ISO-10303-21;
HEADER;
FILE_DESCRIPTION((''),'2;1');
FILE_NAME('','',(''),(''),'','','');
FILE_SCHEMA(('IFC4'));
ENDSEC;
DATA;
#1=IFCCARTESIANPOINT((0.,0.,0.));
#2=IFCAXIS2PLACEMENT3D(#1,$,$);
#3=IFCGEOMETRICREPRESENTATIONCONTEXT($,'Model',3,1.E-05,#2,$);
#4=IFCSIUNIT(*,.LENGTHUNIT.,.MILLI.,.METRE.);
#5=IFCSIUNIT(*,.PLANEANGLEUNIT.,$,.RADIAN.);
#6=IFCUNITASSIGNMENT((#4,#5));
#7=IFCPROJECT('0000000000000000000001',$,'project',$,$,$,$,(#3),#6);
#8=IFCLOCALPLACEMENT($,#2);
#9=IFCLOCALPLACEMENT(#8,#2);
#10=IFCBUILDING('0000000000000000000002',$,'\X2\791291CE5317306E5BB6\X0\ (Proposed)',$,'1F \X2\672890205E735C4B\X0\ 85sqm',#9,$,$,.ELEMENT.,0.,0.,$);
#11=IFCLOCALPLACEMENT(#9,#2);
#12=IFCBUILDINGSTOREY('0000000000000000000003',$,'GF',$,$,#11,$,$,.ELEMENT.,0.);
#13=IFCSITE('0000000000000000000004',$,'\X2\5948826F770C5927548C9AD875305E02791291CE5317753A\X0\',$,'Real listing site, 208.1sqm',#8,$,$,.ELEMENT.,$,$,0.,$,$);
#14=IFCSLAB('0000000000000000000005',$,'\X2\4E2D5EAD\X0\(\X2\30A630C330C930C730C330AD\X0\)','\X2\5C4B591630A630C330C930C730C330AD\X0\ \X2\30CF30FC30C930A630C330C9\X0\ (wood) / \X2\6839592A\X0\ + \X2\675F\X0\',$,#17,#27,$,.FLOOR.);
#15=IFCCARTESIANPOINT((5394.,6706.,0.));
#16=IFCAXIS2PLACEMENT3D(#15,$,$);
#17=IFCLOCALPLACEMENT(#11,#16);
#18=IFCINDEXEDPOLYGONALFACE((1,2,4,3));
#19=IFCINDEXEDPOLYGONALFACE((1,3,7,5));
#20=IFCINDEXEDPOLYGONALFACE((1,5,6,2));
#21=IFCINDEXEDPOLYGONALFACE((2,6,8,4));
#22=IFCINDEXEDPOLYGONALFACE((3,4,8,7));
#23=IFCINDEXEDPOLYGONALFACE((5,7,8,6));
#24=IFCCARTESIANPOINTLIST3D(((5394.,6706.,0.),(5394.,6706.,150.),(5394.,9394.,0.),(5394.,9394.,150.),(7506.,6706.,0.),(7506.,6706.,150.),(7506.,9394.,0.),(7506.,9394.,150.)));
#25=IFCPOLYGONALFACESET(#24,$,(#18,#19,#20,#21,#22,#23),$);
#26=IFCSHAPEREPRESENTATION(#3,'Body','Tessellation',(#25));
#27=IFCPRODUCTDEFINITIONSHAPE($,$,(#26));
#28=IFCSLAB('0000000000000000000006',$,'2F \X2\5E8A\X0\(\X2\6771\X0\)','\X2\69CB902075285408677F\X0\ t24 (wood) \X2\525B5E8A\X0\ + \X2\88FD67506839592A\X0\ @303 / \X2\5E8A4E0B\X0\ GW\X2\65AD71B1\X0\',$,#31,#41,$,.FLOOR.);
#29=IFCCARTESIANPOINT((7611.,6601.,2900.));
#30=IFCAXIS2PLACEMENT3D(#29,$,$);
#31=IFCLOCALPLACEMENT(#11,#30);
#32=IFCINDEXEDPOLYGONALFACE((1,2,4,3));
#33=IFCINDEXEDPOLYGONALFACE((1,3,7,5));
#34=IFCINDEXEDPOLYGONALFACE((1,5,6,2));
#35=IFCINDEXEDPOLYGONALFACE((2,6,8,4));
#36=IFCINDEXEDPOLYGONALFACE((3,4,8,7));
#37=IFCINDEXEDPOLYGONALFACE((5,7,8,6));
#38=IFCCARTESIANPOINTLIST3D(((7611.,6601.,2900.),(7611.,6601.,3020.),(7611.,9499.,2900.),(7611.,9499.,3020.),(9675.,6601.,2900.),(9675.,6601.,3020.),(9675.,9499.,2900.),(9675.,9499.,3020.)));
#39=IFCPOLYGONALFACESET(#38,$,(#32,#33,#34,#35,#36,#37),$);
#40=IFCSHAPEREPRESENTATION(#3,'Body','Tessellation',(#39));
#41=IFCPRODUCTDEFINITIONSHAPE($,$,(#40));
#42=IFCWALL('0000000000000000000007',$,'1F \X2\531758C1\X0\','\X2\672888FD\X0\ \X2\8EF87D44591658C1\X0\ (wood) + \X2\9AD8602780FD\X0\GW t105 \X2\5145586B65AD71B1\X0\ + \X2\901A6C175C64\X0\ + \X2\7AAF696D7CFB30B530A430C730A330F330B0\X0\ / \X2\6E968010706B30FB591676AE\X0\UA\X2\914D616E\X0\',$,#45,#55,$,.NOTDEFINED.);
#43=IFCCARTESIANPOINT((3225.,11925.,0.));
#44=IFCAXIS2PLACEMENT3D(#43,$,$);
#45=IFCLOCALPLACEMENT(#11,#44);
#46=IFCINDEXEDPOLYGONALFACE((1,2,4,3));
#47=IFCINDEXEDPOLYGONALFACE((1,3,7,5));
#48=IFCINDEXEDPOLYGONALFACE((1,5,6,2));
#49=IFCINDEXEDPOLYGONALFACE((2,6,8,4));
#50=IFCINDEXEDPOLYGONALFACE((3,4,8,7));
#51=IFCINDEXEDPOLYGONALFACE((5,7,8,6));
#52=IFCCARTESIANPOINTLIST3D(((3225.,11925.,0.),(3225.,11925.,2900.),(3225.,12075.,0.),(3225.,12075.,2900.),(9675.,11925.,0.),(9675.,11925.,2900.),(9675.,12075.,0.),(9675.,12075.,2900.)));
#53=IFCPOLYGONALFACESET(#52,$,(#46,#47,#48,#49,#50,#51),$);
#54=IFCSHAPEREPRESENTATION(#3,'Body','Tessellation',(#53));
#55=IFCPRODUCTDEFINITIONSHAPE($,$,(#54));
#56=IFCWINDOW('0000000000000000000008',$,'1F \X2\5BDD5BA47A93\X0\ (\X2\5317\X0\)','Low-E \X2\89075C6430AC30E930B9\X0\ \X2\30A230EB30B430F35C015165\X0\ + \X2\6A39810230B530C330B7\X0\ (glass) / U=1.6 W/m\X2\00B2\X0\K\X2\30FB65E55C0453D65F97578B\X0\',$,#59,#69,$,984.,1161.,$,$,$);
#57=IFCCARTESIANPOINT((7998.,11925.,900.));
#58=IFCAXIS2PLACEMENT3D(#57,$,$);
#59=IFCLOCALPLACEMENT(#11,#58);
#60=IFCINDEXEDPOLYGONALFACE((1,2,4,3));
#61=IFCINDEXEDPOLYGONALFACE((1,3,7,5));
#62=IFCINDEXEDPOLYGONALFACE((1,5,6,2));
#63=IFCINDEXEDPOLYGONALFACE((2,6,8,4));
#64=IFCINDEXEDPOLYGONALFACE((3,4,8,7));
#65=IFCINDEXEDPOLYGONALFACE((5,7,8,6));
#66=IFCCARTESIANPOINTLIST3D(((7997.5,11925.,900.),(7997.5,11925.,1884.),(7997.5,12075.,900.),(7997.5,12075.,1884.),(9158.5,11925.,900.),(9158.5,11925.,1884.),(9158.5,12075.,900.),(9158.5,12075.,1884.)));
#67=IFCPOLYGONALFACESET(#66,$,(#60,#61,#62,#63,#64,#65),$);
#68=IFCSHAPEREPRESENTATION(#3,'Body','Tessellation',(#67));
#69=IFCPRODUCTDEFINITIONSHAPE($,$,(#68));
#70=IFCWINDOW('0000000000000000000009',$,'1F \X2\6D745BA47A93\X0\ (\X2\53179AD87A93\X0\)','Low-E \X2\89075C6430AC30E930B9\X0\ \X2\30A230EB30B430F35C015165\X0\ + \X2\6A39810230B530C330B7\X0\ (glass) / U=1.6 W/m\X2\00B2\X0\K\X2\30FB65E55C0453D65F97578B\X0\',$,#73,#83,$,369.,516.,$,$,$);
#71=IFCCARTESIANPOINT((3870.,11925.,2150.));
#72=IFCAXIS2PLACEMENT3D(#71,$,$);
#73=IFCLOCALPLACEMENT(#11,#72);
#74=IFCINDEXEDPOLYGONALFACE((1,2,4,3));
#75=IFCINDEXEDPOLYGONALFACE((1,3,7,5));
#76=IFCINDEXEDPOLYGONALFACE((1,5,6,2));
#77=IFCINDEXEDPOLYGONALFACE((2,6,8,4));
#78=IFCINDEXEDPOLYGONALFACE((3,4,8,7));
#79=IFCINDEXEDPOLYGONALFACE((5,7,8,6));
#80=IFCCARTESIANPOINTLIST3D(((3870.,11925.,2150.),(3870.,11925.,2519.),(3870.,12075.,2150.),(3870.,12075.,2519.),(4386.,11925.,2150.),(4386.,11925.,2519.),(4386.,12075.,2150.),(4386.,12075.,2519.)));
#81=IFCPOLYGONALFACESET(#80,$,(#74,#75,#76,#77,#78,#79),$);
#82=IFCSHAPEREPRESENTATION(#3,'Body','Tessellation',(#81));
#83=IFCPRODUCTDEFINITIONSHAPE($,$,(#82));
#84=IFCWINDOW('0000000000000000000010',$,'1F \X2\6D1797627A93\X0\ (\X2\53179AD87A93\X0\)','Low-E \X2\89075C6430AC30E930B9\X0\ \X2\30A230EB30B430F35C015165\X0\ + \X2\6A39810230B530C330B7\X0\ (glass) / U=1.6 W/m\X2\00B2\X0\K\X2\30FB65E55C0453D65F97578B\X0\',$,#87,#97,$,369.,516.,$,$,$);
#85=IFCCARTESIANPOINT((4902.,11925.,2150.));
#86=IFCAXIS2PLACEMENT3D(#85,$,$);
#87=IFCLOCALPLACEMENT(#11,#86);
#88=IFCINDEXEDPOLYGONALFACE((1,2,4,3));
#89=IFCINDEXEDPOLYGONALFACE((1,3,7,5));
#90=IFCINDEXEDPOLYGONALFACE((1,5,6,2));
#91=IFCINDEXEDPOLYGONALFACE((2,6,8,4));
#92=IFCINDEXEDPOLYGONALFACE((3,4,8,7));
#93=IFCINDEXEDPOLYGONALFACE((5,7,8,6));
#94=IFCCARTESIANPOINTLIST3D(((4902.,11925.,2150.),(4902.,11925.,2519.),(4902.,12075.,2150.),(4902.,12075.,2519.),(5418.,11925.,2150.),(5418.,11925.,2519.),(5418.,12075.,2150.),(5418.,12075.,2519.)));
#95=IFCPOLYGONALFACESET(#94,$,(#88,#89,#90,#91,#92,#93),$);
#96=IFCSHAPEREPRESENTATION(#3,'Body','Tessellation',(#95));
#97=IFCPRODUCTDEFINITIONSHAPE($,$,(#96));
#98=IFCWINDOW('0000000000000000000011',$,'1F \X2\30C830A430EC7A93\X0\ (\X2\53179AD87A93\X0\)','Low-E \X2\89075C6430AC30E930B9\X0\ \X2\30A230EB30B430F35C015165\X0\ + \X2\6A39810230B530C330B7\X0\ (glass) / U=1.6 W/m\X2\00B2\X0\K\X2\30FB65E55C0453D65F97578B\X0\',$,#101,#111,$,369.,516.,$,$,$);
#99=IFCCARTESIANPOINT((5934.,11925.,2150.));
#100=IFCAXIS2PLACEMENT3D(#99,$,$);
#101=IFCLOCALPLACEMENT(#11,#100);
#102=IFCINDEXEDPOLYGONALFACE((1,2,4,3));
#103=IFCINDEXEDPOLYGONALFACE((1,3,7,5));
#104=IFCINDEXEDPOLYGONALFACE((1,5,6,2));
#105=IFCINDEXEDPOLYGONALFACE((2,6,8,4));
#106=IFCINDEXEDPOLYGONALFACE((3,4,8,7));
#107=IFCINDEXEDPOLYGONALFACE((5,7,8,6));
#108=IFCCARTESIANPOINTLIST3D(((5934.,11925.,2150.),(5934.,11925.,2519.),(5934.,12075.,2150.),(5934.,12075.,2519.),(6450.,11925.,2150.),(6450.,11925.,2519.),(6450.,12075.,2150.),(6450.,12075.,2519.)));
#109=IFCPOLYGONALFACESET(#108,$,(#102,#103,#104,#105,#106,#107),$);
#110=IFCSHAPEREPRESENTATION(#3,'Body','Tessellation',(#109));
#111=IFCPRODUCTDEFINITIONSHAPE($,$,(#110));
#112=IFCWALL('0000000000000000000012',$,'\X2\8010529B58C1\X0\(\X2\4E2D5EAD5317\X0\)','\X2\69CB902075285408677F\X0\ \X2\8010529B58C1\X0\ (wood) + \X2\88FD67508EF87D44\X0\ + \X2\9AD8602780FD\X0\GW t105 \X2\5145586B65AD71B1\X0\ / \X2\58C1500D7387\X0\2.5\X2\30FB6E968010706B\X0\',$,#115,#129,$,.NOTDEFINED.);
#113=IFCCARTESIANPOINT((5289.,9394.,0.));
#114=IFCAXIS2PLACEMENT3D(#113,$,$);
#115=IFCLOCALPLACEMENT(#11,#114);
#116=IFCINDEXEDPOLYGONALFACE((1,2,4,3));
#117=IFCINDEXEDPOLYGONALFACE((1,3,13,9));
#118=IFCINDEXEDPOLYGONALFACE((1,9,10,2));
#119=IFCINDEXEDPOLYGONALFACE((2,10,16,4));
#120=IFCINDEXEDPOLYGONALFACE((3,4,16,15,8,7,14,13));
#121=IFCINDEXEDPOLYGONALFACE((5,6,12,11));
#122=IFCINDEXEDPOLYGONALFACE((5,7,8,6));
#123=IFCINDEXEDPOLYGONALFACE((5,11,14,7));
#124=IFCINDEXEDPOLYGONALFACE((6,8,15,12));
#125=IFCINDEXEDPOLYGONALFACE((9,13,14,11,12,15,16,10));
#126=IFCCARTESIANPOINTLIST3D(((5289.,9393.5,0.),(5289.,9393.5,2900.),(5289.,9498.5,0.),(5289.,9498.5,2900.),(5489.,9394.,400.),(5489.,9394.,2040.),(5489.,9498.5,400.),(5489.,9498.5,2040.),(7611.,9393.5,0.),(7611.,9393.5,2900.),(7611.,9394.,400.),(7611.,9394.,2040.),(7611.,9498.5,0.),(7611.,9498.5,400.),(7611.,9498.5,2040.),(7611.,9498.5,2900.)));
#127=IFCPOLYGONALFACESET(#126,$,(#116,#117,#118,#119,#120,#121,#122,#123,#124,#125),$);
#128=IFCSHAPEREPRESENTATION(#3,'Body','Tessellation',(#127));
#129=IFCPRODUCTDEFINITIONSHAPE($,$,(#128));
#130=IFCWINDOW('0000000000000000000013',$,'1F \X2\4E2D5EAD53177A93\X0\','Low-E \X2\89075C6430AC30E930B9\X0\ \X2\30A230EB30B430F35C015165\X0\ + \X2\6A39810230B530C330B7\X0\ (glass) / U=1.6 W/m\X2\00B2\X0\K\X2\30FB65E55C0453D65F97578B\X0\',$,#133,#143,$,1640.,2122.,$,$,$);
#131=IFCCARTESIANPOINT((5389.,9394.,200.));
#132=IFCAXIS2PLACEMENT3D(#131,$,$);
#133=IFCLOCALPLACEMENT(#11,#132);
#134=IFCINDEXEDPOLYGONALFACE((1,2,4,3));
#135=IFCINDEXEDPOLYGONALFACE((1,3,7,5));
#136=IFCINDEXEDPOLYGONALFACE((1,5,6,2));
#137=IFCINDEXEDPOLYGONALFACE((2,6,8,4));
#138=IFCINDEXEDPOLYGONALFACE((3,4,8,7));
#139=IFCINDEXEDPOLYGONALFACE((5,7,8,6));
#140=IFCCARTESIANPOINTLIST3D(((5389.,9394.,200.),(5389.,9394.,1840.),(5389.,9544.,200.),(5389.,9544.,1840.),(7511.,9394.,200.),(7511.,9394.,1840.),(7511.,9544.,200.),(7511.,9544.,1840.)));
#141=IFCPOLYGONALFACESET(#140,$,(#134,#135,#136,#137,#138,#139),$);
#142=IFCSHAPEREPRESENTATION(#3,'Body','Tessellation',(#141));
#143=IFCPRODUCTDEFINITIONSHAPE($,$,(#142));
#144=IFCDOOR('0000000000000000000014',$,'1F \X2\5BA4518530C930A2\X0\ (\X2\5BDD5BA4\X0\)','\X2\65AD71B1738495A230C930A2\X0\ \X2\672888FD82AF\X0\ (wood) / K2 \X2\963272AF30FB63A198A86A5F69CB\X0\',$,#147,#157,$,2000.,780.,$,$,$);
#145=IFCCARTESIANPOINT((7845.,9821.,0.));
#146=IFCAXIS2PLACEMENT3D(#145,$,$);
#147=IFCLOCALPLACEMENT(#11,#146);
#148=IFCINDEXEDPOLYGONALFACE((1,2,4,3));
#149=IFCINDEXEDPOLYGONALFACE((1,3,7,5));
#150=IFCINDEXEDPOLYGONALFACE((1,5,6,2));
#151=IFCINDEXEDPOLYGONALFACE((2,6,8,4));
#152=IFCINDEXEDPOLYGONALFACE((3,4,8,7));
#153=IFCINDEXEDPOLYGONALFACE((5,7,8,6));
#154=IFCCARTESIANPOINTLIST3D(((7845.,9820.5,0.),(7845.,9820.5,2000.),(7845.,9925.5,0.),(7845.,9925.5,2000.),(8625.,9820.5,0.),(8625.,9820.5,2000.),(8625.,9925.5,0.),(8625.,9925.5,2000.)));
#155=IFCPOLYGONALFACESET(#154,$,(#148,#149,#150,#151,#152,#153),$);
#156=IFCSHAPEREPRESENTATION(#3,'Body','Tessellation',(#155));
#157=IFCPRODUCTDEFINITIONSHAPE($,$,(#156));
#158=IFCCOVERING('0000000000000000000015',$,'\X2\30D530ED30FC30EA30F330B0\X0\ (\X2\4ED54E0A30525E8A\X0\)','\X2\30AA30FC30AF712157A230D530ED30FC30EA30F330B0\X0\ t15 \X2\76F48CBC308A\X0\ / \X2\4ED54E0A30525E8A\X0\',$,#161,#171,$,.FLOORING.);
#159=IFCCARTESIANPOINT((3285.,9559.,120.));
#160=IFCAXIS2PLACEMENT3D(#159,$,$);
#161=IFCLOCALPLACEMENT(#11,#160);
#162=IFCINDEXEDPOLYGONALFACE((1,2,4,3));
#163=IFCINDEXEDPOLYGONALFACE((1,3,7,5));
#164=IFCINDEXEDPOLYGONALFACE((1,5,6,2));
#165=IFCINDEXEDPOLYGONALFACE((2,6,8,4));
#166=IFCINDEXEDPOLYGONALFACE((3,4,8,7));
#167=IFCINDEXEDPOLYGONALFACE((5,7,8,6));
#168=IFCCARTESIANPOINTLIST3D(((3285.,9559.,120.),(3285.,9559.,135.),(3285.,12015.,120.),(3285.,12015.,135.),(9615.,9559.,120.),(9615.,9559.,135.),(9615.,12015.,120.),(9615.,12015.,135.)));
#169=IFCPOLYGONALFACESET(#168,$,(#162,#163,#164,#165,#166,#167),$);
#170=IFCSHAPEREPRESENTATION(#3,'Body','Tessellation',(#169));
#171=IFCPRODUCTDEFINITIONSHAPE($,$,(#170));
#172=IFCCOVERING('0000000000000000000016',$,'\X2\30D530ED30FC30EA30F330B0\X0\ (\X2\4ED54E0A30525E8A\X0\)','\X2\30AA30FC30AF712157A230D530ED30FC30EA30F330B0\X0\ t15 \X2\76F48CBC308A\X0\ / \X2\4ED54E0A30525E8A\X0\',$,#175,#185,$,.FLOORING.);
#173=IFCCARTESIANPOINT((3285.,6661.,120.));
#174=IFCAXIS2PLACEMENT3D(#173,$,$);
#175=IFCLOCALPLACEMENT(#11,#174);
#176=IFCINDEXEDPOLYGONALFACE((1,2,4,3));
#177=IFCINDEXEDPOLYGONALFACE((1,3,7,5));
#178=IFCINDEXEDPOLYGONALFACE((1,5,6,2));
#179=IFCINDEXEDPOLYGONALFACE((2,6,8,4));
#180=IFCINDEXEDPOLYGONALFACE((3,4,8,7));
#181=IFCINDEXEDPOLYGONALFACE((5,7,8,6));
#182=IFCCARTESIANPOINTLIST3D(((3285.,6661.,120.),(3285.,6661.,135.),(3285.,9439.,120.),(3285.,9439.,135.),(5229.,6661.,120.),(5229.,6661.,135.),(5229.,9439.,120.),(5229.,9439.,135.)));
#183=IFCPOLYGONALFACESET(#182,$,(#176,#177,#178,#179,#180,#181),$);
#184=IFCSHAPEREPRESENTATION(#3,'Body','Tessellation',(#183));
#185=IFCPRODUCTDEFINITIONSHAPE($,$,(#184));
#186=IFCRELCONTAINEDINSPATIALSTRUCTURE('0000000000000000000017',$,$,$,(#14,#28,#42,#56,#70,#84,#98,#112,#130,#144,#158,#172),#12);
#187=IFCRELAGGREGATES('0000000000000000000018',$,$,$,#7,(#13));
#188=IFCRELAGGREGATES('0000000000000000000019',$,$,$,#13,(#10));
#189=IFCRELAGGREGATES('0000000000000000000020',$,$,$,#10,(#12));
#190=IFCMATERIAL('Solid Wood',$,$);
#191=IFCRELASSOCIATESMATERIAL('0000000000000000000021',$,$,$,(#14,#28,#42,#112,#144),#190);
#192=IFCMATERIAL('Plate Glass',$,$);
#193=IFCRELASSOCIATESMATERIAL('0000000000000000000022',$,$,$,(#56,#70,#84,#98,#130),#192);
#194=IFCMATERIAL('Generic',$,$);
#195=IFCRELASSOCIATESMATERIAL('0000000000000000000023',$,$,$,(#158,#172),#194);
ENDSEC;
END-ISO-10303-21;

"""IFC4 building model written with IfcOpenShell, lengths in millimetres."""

from ifc_helpers import new_model, si_unit, frame, frame_2d, origin, place, context, project, spatial, rectangle, extrude, material, element, fill, save


model = new_model("IFC4")

# Units and contexts
model_context = context("Model", 3, precision=1e-05, world=origin())
ifc_project = project(units=[si_unit("LENGTHUNIT", "METRE", prefix="MILLI"), si_unit("PLANEANGLEUNIT", "RADIAN")], contexts=[model_context])

# Site, building, storey
site_placement = place(None, origin())
site = spatial("IfcSite", under=ifc_project, at=site_placement, Name="奈良県大和高田市礒野北町", ObjectType="Real listing site, 208.1sqm", CompositionType="ELEMENT", RefElevation=0.0)
building_placement = place(site_placement, origin())
building = spatial("IfcBuilding", under=site, at=building_placement, Name="礒野北の家 (Proposed)", ObjectType="1F 木造平屋 85sqm", CompositionType="ELEMENT", ElevationOfRefHeight=0.0, ElevationOfTerrain=0.0)
storey_placement = place(building_placement, origin())
storey = spatial("IfcBuildingStorey", under=building, at=storey_placement, Name="GF", CompositionType="ELEMENT", Elevation=0.0)

# Slabs
ifc_material_1 = material(Name="Solid Wood")
slab_1_placement = place(storey_placement, frame((5394.0, 6706.0, 0.0)))
element("IfcSlab", 1, at=slab_1_placement, inside=storey, material=ifc_material_1, Name="中庭(ウッドデッキ)", Description="屋外ウッドデッキ ハードウッド (wood) / 根太 + 束", PredefinedType="FLOOR", context=model_context, shape_type="SweptSolid", body=[
    extrude(rectangle(XDim=2112.0, YDim=2688.0, at=frame_2d((1056.0, 1344.0))), frame((5394.0, 6706.0, 0.0)), (0.0, 0.0, 1.0), 150.0),
])
slab_2_placement = place(storey_placement, frame((7611.0, 6601.0, 2900.0)))
element("IfcSlab", 2, at=slab_2_placement, inside=storey, material=ifc_material_1, Name="2F 床(東)", Description="構造用合板 t24 (wood) 剛床 + 製材根太 @303 / 床下 GW断熱", PredefinedType="FLOOR", context=model_context, shape_type="SweptSolid", body=[
    extrude(rectangle(XDim=2064.0, YDim=2898.0, at=frame_2d((1032.0, 1449.0))), frame((7611.0, 6601.0, 2900.0)), (0.0, 0.0, 1.0), 120.0),
])

# Wall, openings, windows
wall_1_placement = place(storey_placement, frame((3225.0, 11925.0, 0.0)))
wall_1 = element("IfcWall", 3, at=wall_1_placement, inside=storey, material=ifc_material_1, Name="1F 北壁", Description="木製 軸組外壁 (wood) + 高性能GW t105 充填断熱 + 通気層 + 窯業系サイディング / 準耐火・外皮UA配慮", PredefinedType="NOTDEFINED", context=model_context, shape_type="SweptSolid", body=[
    extrude(rectangle(XDim=6450.0, YDim=150.0, at=frame_2d((3225.0, 75.0))), frame((3225.0, 11925.0, 0.0)), (0.0, 0.0, 1.0), 2900.0),
])
opening_1_placement = place(storey_placement, frame((7998.0, 11925.0, 900.0)))
opening_1 = element("IfcOpeningElement", 4, at=opening_1_placement, cuts=wall_1, PredefinedType="NOTDEFINED", context=model_context, shape_type="SweptSolid", body=[
    extrude(rectangle(XDim=1161.0, YDim=150.0, at=frame_2d((580.0, 75.0))), frame((7998.0, 11925.0, 900.0)), (0.0, 0.0, 1.0), 984.0),
])
opening_2_placement = place(storey_placement, frame((3870.0, 11925.0, 2150.0)))
opening_2 = element("IfcOpeningElement", 5, at=opening_2_placement, cuts=wall_1, PredefinedType="NOTDEFINED", context=model_context, shape_type="SweptSolid", body=[
    extrude(rectangle(XDim=516.0, YDim=150.0, at=frame_2d((258.0, 75.0))), frame((3870.0, 11925.0, 2150.0)), (0.0, 0.0, 1.0), 369.0),
])
opening_3_placement = place(storey_placement, frame((4902.0, 11925.0, 2150.0)))
opening_3 = element("IfcOpeningElement", 6, at=opening_3_placement, cuts=wall_1, PredefinedType="NOTDEFINED", context=model_context, shape_type="SweptSolid", body=[
    extrude(rectangle(XDim=516.0, YDim=150.0, at=frame_2d((258.0, 75.0))), frame((4902.0, 11925.0, 2150.0)), (0.0, 0.0, 1.0), 369.0),
])
opening_4_placement = place(storey_placement, frame((5934.0, 11925.0, 2150.0)))
opening_4 = element("IfcOpeningElement", 7, at=opening_4_placement, cuts=wall_1, PredefinedType="NOTDEFINED", context=model_context, shape_type="SweptSolid", body=[
    extrude(rectangle(XDim=516.0, YDim=150.0, at=frame_2d((258.0, 75.0))), frame((5934.0, 11925.0, 2150.0)), (0.0, 0.0, 1.0), 369.0),
])
ifc_material_2 = material(Name="Plate Glass")
window_1_placement = place(storey_placement, frame((7998.0, 11925.0, 900.0)))
window_1 = element("IfcWindow", 8, at=window_1_placement, inside=storey, material=ifc_material_2, Name="1F 寝室窓 (北)", Description="Low-E 複層ガラス アルゴン封入 + 樹脂サッシ (glass) / U=1.6 W/m²K・日射取得型", OverallHeight=984.0, OverallWidth=1161.0, context=model_context, shape_type="SweptSolid", body=[
    extrude(rectangle(XDim=1161.0, YDim=150.0, at=frame_2d((580.0, 75.0))), frame((7998.0, 11925.0, 900.0)), (0.0, 0.0, 1.0), 984.0),
])
fill(opening_1, window_1)
window_2_placement = place(storey_placement, frame((3870.0, 11925.0, 2150.0)))
window_2 = element("IfcWindow", 9, at=window_2_placement, inside=storey, material=ifc_material_2, Name="1F 浴室窓 (北高窓)", Description="Low-E 複層ガラス アルゴン封入 + 樹脂サッシ (glass) / U=1.6 W/m²K・日射取得型", OverallHeight=369.0, OverallWidth=516.0, context=model_context, shape_type="SweptSolid", body=[
    extrude(rectangle(XDim=516.0, YDim=150.0, at=frame_2d((258.0, 75.0))), frame((3870.0, 11925.0, 2150.0)), (0.0, 0.0, 1.0), 369.0),
])
fill(opening_2, window_2)
window_3_placement = place(storey_placement, frame((4902.0, 11925.0, 2150.0)))
window_3 = element("IfcWindow", 10, at=window_3_placement, inside=storey, material=ifc_material_2, Name="1F 洗面窓 (北高窓)", Description="Low-E 複層ガラス アルゴン封入 + 樹脂サッシ (glass) / U=1.6 W/m²K・日射取得型", OverallHeight=369.0, OverallWidth=516.0, context=model_context, shape_type="SweptSolid", body=[
    extrude(rectangle(XDim=516.0, YDim=150.0, at=frame_2d((258.0, 75.0))), frame((4902.0, 11925.0, 2150.0)), (0.0, 0.0, 1.0), 369.0),
])
fill(opening_3, window_3)
window_4_placement = place(storey_placement, frame((5934.0, 11925.0, 2150.0)))
window_4 = element("IfcWindow", 11, at=window_4_placement, inside=storey, material=ifc_material_2, Name="1F トイレ窓 (北高窓)", Description="Low-E 複層ガラス アルゴン封入 + 樹脂サッシ (glass) / U=1.6 W/m²K・日射取得型", OverallHeight=369.0, OverallWidth=516.0, context=model_context, shape_type="SweptSolid", body=[
    extrude(rectangle(XDim=516.0, YDim=150.0, at=frame_2d((258.0, 75.0))), frame((5934.0, 11925.0, 2150.0)), (0.0, 0.0, 1.0), 369.0),
])
fill(opening_4, window_4)

# Wall, opening, window
wall_2_placement = place(storey_placement, frame((5289.0, 9394.0, 0.0)))
wall_2 = element("IfcWall", 12, at=wall_2_placement, inside=storey, material=ifc_material_1, Name="耐力壁(中庭北)", Description="構造用合板 耐力壁 (wood) + 製材軸組 + 高性能GW t105 充填断熱 / 壁倍率2.5・準耐火", PredefinedType="NOTDEFINED", context=model_context, shape_type="SweptSolid", body=[
    extrude(rectangle(XDim=2322.0, YDim=105.0, at=frame_2d((1161.0, 52.0))), frame((5289.0, 9394.0, 0.0)), (0.0, 0.0, 1.0), 2900.0),
])
opening_5_placement = place(storey_placement, frame((5389.0, 9394.0, 200.0)))
opening_5 = element("IfcOpeningElement", 13, at=opening_5_placement, cuts=wall_2, PredefinedType="NOTDEFINED", context=model_context, shape_type="SweptSolid", body=[
    extrude(rectangle(XDim=2122.0, YDim=150.0, at=frame_2d((1061.0, 75.0))), frame((5389.0, 9394.0, 200.0)), (0.0, 0.0, 1.0), 1640.0),
])
window_5_placement = place(storey_placement, frame((5389.0, 9394.0, 200.0)))
window_5 = element("IfcWindow", 14, at=window_5_placement, inside=storey, material=ifc_material_2, Name="1F 中庭北窓", Description="Low-E 複層ガラス アルゴン封入 + 樹脂サッシ (glass) / U=1.6 W/m²K・日射取得型", OverallHeight=1640.0, OverallWidth=2122.0, context=model_context, shape_type="SweptSolid", body=[
    extrude(rectangle(XDim=2122.0, YDim=150.0, at=frame_2d((1061.0, 75.0))), frame((5389.0, 9394.0, 200.0)), (0.0, 0.0, 1.0), 1640.0),
])
fill(opening_5, window_5)

# Door
door_1_placement = place(storey_placement, frame((7845.0, 9821.0, 0.0)))
element("IfcDoor", 15, at=door_1_placement, inside=storey, material=ifc_material_1, Name="1F 室内ドア (寝室)", Description="断熱玄関ドア 木製芯 (wood) / K2 防犯・採風機構", OverallHeight=2000.0, OverallWidth=780.0, context=model_context, shape_type="SweptSolid", body=[
    extrude(rectangle(XDim=780.0, YDim=105.0, at=frame_2d((390.0, 52.0))), frame((7845.0, 9821.0, 0.0)), (0.0, 0.0, 1.0), 2000.0),
])

# Coverings
ifc_material_3 = material(Name="Generic")
covering_1_placement = place(storey_placement, frame((3285.0, 9559.0, 120.0)))
element("IfcCovering", 16, at=covering_1_placement, inside=storey, material=ifc_material_3, Name="フローリング (仕上げ床)", Description="オーク無垢フローリング t15 直貼り / 仕上げ床", PredefinedType="FLOORING", context=model_context, shape_type="SweptSolid", body=[
    extrude(rectangle(XDim=6330.0, YDim=2456.0, at=frame_2d((3165.0, 1228.0))), frame((3285.0, 9559.0, 120.0)), (0.0, 0.0, 1.0), 15.0),
])
covering_2_placement = place(storey_placement, frame((3285.0, 6661.0, 120.0)))
element("IfcCovering", 17, at=covering_2_placement, inside=storey, material=ifc_material_3, Name="フローリング (仕上げ床)", Description="オーク無垢フローリング t15 直貼り / 仕上げ床", PredefinedType="FLOORING", context=model_context, shape_type="SweptSolid", body=[
    extrude(rectangle(XDim=1944.0, YDim=2778.0, at=frame_2d((972.0, 1389.0))), frame((3285.0, 6661.0, 120.0)), (0.0, 0.0, 1.0), 15.0),
])

save(model, "model.ifc")
